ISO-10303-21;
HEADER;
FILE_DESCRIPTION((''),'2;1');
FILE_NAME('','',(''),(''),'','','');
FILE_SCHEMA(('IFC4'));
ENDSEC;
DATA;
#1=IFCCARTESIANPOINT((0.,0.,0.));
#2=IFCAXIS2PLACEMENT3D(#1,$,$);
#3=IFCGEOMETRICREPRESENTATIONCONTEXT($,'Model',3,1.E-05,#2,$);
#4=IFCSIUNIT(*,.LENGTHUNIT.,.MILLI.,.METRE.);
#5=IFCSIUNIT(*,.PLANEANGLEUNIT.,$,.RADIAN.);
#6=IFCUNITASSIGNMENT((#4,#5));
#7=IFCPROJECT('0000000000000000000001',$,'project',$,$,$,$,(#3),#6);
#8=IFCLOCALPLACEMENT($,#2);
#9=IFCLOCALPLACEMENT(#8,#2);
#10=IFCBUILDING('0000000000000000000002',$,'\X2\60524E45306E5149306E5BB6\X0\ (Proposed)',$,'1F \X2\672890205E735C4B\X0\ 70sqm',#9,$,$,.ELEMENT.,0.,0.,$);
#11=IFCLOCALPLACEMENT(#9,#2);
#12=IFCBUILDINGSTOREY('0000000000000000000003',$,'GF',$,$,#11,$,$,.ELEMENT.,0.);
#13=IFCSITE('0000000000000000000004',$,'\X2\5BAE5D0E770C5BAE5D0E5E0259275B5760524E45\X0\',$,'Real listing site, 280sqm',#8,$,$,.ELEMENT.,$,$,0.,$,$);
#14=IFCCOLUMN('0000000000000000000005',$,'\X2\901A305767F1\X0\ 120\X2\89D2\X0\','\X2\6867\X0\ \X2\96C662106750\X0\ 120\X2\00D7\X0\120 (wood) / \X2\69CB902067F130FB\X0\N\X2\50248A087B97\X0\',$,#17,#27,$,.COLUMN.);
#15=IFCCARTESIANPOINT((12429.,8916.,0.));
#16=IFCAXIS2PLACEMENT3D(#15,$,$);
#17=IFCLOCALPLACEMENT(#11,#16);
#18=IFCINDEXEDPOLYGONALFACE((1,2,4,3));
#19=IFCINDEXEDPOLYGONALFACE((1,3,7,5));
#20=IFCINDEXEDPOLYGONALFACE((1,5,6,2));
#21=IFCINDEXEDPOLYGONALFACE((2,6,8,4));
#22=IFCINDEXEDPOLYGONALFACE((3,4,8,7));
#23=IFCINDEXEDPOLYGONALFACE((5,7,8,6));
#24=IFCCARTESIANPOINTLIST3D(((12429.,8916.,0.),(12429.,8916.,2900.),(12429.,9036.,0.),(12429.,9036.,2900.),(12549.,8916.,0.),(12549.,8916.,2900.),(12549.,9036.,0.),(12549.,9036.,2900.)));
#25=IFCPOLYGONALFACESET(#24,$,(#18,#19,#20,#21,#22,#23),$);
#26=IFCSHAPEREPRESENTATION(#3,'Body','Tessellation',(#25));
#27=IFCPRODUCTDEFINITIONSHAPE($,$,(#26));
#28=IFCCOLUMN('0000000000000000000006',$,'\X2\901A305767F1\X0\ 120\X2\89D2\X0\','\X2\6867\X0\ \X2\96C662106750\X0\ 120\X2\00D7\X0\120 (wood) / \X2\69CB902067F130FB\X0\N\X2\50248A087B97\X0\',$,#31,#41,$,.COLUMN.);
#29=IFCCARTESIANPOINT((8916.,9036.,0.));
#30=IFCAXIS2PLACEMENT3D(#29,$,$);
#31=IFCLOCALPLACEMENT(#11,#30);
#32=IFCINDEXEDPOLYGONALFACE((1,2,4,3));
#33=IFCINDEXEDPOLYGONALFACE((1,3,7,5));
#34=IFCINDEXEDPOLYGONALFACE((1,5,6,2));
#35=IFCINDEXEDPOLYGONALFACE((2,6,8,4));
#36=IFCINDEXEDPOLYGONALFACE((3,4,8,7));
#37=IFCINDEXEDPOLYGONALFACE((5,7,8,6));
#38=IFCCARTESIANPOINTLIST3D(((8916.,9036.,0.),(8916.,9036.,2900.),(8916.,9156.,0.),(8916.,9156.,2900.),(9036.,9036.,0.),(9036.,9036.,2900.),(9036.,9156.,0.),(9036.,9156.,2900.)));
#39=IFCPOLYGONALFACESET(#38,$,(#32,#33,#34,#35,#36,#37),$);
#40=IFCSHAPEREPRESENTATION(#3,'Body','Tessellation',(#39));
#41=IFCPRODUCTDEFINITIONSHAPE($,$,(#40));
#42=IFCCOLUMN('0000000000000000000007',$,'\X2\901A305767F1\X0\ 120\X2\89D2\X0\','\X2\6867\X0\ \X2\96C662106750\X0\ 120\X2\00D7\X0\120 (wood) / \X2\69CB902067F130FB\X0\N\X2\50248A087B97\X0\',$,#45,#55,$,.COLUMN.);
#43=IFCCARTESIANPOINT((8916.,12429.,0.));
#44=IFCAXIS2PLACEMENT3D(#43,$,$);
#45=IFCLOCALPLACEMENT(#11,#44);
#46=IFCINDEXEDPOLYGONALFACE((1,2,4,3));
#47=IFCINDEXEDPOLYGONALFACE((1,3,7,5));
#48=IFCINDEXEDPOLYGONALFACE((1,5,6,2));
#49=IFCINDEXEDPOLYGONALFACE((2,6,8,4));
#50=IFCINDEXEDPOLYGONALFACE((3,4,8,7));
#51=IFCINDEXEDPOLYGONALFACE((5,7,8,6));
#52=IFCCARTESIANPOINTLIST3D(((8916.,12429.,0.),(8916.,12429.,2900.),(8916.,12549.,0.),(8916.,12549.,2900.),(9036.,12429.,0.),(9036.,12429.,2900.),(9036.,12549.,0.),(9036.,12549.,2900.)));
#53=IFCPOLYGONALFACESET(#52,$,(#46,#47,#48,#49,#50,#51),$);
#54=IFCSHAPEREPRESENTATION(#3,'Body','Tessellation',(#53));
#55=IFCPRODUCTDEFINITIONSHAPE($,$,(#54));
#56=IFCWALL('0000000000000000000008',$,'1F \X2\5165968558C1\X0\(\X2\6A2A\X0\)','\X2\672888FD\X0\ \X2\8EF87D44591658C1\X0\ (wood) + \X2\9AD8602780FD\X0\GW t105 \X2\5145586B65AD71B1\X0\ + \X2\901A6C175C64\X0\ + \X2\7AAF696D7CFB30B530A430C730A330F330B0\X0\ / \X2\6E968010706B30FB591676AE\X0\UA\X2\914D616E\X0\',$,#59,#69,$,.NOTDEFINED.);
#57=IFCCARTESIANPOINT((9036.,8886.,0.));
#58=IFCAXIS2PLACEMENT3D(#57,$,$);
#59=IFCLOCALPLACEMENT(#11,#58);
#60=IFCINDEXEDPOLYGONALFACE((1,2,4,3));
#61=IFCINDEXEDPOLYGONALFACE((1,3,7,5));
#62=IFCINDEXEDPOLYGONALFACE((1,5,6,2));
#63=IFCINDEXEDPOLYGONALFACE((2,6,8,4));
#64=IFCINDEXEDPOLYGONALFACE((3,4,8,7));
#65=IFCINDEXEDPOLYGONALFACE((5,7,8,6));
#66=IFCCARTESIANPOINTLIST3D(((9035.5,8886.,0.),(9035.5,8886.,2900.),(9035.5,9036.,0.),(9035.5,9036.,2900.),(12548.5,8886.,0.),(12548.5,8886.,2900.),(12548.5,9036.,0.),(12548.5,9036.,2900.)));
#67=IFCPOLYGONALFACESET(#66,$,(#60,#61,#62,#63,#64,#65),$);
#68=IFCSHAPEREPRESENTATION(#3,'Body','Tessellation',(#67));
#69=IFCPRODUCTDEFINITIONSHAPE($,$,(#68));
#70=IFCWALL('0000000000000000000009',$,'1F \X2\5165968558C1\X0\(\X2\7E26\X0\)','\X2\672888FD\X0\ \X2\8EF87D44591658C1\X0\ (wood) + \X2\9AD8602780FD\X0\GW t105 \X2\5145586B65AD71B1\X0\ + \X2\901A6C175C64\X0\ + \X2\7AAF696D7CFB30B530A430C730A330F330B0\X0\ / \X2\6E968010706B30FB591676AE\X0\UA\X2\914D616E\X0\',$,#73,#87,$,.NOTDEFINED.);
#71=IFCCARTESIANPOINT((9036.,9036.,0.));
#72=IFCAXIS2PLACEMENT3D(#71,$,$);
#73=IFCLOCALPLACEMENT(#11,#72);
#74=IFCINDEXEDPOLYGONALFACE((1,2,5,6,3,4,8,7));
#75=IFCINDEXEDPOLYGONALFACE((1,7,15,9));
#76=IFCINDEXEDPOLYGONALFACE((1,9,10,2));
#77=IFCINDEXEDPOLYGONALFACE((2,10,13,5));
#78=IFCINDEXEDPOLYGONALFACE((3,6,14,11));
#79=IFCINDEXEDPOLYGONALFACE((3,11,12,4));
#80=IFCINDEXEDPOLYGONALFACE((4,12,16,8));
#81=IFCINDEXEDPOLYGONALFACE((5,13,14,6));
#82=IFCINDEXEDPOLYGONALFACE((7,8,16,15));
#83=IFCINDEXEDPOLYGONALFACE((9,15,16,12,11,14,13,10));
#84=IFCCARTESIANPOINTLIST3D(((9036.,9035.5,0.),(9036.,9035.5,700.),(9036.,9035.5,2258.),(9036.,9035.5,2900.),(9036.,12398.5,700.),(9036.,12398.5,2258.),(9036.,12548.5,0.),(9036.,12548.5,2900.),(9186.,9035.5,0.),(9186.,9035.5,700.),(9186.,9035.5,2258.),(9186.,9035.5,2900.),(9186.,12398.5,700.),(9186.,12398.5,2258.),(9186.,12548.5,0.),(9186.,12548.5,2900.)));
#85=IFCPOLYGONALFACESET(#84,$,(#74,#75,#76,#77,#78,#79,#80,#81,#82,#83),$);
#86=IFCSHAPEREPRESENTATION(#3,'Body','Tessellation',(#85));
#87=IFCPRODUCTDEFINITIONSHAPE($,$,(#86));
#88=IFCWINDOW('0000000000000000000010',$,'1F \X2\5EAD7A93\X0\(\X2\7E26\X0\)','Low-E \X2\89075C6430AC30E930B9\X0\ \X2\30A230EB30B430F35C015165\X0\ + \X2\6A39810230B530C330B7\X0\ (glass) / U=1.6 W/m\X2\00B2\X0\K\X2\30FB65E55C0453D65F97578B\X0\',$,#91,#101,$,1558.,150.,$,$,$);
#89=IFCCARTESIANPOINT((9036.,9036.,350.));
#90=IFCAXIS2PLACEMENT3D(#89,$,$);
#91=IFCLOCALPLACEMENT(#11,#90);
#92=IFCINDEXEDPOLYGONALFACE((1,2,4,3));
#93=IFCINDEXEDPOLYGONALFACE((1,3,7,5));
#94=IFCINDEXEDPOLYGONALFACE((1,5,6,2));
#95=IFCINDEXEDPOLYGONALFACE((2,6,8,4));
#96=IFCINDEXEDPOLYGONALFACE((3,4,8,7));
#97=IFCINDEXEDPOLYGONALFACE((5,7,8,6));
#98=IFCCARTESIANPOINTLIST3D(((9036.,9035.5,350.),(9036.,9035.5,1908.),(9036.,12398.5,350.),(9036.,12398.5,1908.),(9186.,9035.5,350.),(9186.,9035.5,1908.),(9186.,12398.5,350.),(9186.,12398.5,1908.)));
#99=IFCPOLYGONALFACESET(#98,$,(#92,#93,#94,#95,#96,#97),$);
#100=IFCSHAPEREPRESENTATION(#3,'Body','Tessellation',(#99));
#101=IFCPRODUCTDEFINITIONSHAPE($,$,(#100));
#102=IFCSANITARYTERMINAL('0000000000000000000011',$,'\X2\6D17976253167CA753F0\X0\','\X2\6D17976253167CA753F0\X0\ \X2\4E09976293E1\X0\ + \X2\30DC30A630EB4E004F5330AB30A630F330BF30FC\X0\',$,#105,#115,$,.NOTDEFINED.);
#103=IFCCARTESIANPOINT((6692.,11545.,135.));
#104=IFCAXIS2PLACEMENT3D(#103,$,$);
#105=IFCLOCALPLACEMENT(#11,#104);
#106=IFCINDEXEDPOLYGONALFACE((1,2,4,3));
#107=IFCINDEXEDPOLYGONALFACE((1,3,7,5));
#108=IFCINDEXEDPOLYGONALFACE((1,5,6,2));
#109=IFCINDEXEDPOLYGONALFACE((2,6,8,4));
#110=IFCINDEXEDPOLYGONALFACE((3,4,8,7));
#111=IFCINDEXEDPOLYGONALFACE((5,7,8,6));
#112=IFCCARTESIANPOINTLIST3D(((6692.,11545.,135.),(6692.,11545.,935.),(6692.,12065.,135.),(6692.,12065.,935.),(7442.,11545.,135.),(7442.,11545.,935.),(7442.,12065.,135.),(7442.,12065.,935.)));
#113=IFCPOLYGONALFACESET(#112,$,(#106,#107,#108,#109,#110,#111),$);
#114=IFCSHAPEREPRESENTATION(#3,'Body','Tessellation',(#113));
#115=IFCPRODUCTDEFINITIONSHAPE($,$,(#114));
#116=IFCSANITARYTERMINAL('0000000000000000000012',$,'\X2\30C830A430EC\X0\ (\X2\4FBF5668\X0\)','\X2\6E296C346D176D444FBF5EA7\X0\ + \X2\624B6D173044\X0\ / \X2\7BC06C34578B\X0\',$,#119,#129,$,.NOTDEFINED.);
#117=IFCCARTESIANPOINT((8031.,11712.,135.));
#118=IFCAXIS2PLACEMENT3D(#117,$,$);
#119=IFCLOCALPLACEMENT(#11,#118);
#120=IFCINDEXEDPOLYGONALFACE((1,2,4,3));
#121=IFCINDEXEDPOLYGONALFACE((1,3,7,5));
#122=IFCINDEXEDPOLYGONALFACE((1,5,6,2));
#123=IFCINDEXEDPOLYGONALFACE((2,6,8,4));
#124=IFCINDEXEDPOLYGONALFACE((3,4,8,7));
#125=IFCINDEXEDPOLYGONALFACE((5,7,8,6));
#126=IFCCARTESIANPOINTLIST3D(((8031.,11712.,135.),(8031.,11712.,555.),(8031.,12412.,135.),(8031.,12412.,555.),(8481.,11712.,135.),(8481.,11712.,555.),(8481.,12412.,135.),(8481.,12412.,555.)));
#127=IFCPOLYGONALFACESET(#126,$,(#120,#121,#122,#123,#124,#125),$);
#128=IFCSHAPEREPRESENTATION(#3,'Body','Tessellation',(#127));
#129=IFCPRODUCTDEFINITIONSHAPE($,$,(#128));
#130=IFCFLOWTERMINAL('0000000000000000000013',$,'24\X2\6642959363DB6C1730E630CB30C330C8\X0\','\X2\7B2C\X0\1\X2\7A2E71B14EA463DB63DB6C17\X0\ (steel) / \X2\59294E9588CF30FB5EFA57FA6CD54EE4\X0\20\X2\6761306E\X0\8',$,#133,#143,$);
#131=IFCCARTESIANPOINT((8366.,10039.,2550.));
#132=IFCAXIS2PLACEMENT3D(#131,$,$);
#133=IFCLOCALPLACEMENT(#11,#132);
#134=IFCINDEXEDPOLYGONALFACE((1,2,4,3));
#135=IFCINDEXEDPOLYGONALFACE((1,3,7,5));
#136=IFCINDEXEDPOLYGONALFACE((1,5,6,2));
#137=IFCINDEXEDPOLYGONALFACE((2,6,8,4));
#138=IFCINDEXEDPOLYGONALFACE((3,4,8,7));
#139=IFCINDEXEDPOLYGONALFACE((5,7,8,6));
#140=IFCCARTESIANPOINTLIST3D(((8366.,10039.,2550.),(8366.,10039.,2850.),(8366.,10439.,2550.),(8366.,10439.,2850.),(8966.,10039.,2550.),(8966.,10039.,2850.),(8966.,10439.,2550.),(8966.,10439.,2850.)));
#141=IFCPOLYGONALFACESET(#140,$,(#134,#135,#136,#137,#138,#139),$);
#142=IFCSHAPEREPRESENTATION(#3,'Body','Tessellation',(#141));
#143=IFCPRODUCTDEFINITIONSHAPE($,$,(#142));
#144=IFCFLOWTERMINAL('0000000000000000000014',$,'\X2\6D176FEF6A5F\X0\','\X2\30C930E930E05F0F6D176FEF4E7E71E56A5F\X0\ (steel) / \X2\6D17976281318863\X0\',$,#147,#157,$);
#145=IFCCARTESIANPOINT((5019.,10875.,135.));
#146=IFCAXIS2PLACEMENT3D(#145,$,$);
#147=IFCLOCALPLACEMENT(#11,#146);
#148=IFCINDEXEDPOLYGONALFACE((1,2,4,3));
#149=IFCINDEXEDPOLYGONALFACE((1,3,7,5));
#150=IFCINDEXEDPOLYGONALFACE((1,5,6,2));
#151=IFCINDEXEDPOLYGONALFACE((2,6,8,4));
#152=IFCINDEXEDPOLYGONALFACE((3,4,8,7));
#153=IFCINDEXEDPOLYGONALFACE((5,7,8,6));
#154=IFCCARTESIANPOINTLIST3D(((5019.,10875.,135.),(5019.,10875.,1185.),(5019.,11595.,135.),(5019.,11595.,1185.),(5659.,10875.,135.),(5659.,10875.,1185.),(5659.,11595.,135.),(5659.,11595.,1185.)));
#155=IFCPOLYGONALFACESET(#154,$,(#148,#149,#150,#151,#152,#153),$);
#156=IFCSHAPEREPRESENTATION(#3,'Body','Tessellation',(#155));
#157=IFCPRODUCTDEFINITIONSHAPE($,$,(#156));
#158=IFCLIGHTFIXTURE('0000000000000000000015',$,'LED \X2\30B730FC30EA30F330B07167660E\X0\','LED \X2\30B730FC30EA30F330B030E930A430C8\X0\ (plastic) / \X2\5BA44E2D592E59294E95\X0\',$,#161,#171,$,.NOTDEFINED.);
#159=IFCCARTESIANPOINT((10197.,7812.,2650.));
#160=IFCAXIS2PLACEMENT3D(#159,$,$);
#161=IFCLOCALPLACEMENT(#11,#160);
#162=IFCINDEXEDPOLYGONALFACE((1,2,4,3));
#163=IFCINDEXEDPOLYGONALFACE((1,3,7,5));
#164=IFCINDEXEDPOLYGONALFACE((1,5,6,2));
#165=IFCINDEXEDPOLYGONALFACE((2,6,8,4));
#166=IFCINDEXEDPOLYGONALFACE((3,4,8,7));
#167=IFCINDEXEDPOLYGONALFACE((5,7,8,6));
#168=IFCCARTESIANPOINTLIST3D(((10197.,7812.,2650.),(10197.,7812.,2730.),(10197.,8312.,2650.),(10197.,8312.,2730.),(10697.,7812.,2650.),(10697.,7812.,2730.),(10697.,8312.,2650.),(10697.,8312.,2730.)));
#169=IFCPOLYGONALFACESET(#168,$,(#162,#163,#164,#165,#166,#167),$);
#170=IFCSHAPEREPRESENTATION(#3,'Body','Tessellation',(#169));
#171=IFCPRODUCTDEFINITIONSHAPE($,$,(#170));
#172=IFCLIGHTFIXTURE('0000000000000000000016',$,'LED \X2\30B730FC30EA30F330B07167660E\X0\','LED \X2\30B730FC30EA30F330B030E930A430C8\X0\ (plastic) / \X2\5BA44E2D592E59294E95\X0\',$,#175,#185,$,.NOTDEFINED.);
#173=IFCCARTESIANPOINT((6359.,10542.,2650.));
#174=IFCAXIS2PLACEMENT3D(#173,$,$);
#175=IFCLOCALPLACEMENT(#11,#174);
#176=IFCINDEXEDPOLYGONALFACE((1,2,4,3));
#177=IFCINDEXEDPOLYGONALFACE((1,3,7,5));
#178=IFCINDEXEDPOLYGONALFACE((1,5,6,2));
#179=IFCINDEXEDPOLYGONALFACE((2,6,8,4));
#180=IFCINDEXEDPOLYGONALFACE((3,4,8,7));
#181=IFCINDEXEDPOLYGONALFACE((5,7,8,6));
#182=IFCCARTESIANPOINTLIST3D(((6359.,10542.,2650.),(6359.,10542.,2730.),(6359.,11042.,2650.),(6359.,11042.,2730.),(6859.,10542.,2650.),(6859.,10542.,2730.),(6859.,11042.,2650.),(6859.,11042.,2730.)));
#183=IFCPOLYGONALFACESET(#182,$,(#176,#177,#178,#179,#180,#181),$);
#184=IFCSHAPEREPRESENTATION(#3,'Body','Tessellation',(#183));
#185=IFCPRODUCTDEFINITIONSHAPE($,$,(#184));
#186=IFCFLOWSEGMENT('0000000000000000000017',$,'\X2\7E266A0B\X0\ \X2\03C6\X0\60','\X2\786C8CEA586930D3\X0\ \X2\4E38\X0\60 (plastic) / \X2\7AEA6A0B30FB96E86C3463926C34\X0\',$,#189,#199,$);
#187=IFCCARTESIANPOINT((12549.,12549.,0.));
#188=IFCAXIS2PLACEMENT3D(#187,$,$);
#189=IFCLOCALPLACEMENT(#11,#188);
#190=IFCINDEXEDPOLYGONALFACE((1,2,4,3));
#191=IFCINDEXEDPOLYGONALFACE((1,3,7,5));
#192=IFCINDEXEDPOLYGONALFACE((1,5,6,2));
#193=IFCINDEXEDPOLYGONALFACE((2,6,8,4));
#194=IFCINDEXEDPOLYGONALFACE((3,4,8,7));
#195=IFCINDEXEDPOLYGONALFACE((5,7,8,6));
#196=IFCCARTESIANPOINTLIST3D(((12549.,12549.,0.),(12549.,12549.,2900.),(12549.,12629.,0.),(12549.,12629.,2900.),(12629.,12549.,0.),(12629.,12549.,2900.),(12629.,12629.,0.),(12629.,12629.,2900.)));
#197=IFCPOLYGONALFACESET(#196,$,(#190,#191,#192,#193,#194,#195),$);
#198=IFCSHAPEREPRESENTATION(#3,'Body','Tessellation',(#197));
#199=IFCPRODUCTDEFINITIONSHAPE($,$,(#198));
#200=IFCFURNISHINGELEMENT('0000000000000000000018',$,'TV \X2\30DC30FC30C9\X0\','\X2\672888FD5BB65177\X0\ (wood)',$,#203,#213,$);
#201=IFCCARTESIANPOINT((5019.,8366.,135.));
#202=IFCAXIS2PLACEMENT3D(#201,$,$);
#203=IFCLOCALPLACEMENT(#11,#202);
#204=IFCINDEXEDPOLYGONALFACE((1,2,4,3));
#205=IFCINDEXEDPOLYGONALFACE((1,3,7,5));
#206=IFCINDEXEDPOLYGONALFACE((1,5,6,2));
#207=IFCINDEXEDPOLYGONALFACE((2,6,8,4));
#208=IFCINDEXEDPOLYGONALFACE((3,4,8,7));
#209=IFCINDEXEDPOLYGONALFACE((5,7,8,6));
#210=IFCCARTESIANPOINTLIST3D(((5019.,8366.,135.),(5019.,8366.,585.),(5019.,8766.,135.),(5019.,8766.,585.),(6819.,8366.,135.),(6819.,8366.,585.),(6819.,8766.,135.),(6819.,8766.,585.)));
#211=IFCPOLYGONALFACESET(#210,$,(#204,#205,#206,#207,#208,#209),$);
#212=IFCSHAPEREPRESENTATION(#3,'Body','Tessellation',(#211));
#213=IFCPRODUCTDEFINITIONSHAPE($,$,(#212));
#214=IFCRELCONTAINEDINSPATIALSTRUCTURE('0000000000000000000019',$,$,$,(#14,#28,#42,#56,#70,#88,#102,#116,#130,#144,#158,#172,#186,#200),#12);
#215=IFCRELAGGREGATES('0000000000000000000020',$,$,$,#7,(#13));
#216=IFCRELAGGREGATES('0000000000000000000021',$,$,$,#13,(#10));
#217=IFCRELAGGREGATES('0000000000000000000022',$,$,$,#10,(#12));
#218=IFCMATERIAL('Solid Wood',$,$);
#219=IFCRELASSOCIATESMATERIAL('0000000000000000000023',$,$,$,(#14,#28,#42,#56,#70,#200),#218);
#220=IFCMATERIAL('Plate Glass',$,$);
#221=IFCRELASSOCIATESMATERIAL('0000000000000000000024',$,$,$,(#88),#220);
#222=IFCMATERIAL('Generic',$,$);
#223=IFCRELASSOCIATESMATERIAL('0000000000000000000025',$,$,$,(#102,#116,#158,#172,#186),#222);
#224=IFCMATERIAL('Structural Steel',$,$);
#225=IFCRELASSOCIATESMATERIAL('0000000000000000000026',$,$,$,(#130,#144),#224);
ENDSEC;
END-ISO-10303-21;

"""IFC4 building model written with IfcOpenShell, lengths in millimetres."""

from ifc_helpers import new_model, si_unit, frame, frame_2d, origin, place, context, project, spatial, rectangle, extrude, material, element, fill, save


model = new_model("IFC4")

# Units and contexts
model_context = context("Model", 3, precision=1e-05, world=origin())
ifc_project = project(units=[si_unit("LENGTHUNIT", "METRE", prefix="MILLI"), si_unit("PLANEANGLEUNIT", "RADIAN")], contexts=[model_context])

# Site, building, storey
site_placement = place(None, origin())
site = spatial("IfcSite", under=ifc_project, at=site_placement, Name="宮崎県宮崎市大字恒久", ObjectType="Real listing site, 280sqm", CompositionType="ELEMENT", RefElevation=0.0)
building_placement = place(site_placement, origin())
building = spatial("IfcBuilding", under=site, at=building_placement, Name="恒久の光の家 (Proposed)", ObjectType="1F 木造平屋 70sqm", CompositionType="ELEMENT", ElevationOfRefHeight=0.0, ElevationOfTerrain=0.0)
storey_placement = place(building_placement, origin())
storey = spatial("IfcBuildingStorey", under=building, at=storey_placement, Name="GF", CompositionType="ELEMENT", Elevation=0.0)

# Columns
ifc_material_1 = material(Name="Solid Wood")
column_1_placement = place(storey_placement, frame((12429.0, 8916.0, 0.0)))
element("IfcColumn", 1, at=column_1_placement, inside=storey, material=ifc_material_1, Name="通し柱 120角", Description="桧 集成材 120×120 (wood) / 構造柱・N値計算", PredefinedType="COLUMN", context=model_context, shape_type="SweptSolid", body=[
    extrude(rectangle(XDim=120.0, YDim=120.0, at=frame_2d((60.0, 60.0))), frame((12429.0, 8916.0, 0.0)), (0.0, 0.0, 1.0), 2900.0),
])
column_2_placement = place(storey_placement, frame((8916.0, 9036.0, 0.0)))
element("IfcColumn", 2, at=column_2_placement, inside=storey, material=ifc_material_1, Name="通し柱 120角", Description="桧 集成材 120×120 (wood) / 構造柱・N値計算", PredefinedType="COLUMN", context=model_context, shape_type="SweptSolid", body=[
    extrude(rectangle(XDim=120.0, YDim=120.0, at=frame_2d((60.0, 60.0))), frame((8916.0, 9036.0, 0.0)), (0.0, 0.0, 1.0), 2900.0),
])
column_3_placement = place(storey_placement, frame((8916.0, 12429.0, 0.0)))
element("IfcColumn", 3, at=column_3_placement, inside=storey, material=ifc_material_1, Name="通し柱 120角", Description="桧 集成材 120×120 (wood) / 構造柱・N値計算", PredefinedType="COLUMN", context=model_context, shape_type="SweptSolid", body=[
    extrude(rectangle(XDim=120.0, YDim=120.0, at=frame_2d((60.0, 60.0))), frame((8916.0, 12429.0, 0.0)), (0.0, 0.0, 1.0), 2900.0),
])

# Wall
wall_1_placement = place(storey_placement, frame((9036.0, 8886.0, 0.0)))
element("IfcWall", 4, at=wall_1_placement, inside=storey, material=ifc_material_1, Name="1F 入隅壁(横)", Description="木製 軸組外壁 (wood) + 高性能GW t105 充填断熱 + 通気層 + 窯業系サイディング / 準耐火・外皮UA配慮", PredefinedType="NOTDEFINED", context=model_context, shape_type="SweptSolid", body=[
    extrude(rectangle(XDim=3513.0, YDim=150.0, at=frame_2d((1756.0, 75.0))), frame((9036.0, 8886.0, 0.0)), (0.0, 0.0, 1.0), 2900.0),
])

# Wall, opening, window
wall_2_placement = place(storey_placement, frame((9036.0, 9036.0, 0.0)))
wall_2 = element("IfcWall", 5, at=wall_2_placement, inside=storey, material=ifc_material_1, Name="1F 入隅壁(縦)", Description="木製 軸組外壁 (wood) + 高性能GW t105 充填断熱 + 通気層 + 窯業系サイディング / 準耐火・外皮UA配慮", PredefinedType="NOTDEFINED", context=model_context, shape_type="SweptSolid", body=[
    extrude(rectangle(XDim=150.0, YDim=3513.0, at=frame_2d((75.0, 1756.0))), frame((9036.0, 9036.0, 0.0)), (0.0, 0.0, 1.0), 2900.0),
])
opening_placement = place(storey_placement, frame((9036.0, 9036.0, 350.0)))
opening = element("IfcOpeningElement", 6, at=opening_placement, cuts=wall_2, PredefinedType="NOTDEFINED", context=model_context, shape_type="SweptSolid", body=[
    extrude(rectangle(XDim=150.0, YDim=3363.0, at=frame_2d((75.0, 1681.0))), frame((9036.0, 9036.0, 350.0)), (0.0, 0.0, 1.0), 1558.0),
])
ifc_material_2 = material(Name="Plate Glass")
window_placement = place(storey_placement, frame((9036.0, 9036.0, 350.0)))
window = element("IfcWindow", 7, at=window_placement, inside=storey, material=ifc_material_2, Name="1F 庭窓(縦)", Description="Low-E 複層ガラス アルゴン封入 + 樹脂サッシ (glass) / U=1.6 W/m²K・日射取得型", OverallHeight=1558.0, OverallWidth=150.0, context=model_context, shape_type="SweptSolid", body=[
    extrude(rectangle(XDim=150.0, YDim=3363.0, at=frame_2d((75.0, 1681.0))), frame((9036.0, 9036.0, 350.0)), (0.0, 0.0, 1.0), 1558.0),
])
fill(opening, window)

# Sanitary terminals
ifc_material_3 = material(Name="Generic")
sanitary_terminal_1_placement = place(storey_placement, frame((6692.0, 11545.0, 135.0)))
element("IfcSanitaryTerminal", 8, at=sanitary_terminal_1_placement, inside=storey, material=ifc_material_3, Name="洗面化粧台", Description="洗面化粧台 三面鏡 + ボウル一体カウンター", PredefinedType="NOTDEFINED", context=model_context, shape_type="SweptSolid", body=[
    extrude(rectangle(XDim=750.0, YDim=520.0, at=frame_2d((375.0, 260.0))), frame((6692.0, 11545.0, 135.0)), (0.0, 0.0, 1.0), 800.0),
])
sanitary_terminal_2_placement = place(storey_placement, frame((8031.0, 11712.0, 135.0)))
element("IfcSanitaryTerminal", 9, at=sanitary_terminal_2_placement, inside=storey, material=ifc_material_3, Name="トイレ (便器)", Description="温水洗浄便座 + 手洗い / 節水型", PredefinedType="NOTDEFINED", context=model_context, shape_type="SweptSolid", body=[
    extrude(rectangle(XDim=450.0, YDim=700.0, at=frame_2d((225.0, 350.0))), frame((8031.0, 11712.0, 135.0)), (0.0, 0.0, 1.0), 420.0),
])

# Flow terminals
ifc_material_4 = material(Name="Structural Steel")
flow_terminal_1_placement = place(storey_placement, frame((8366.0, 10039.0, 2550.0)))
element("IfcFlowTerminal", 10, at=flow_terminal_1_placement, inside=storey, material=ifc_material_4, Name="24時間換気ユニット", Description="第1種熱交換換気 (steel) / 天井裏・建基法令20条の8", context=model_context, shape_type="SweptSolid", body=[
    extrude(rectangle(XDim=600.0, YDim=400.0, at=frame_2d((300.0, 200.0))), frame((8366.0, 10039.0, 2550.0)), (0.0, 0.0, 1.0), 300.0),
])
flow_terminal_2_placement = place(storey_placement, frame((5019.0, 10875.0, 135.0)))
element("IfcFlowTerminal", 11, at=flow_terminal_2_placement, inside=storey, material=ifc_material_4, Name="洗濯機", Description="ドラム式洗濯乾燥機 (steel) / 洗面脱衣", context=model_context, shape_type="SweptSolid", body=[
    extrude(rectangle(XDim=640.0, YDim=720.0, at=frame_2d((320.0, 360.0))), frame((5019.0, 10875.0, 135.0)), (0.0, 0.0, 1.0), 1050.0),
])

# Light fixtures
light_fixture_1_placement = place(storey_placement, frame((10197.0, 7812.0, 2650.0)))
element("IfcLightFixture", 12, at=light_fixture_1_placement, inside=storey, material=ifc_material_3, Name="LED シーリング照明", Description="LED シーリングライト (plastic) / 室中央天井", PredefinedType="NOTDEFINED", context=model_context, shape_type="SweptSolid", body=[
    extrude(rectangle(XDim=500.0, YDim=500.0, at=frame_2d((250.0, 250.0))), frame((10197.0, 7812.0, 2650.0)), (0.0, 0.0, 1.0), 80.0),
])
light_fixture_2_placement = place(storey_placement, frame((6359.0, 10542.0, 2650.0)))
element("IfcLightFixture", 13, at=light_fixture_2_placement, inside=storey, material=ifc_material_3, Name="LED シーリング照明", Description="LED シーリングライト (plastic) / 室中央天井", PredefinedType="NOTDEFINED", context=model_context, shape_type="SweptSolid", body=[
    extrude(rectangle(XDim=500.0, YDim=500.0, at=frame_2d((250.0, 250.0))), frame((6359.0, 10542.0, 2650.0)), (0.0, 0.0, 1.0), 80.0),
])

# Flow segment
flow_segment_placement = place(storey_placement, frame((12549.0, 12549.0, 0.0)))
element("IfcFlowSegment", 14, at=flow_segment_placement, inside=storey, material=ifc_material_3, Name="縦樋 φ60", Description="硬質塩ビ 丸60 (plastic) / 竪樋・雨水排水", context=model_context, shape_type="SweptSolid", body=[
    extrude(rectangle(XDim=80.0, YDim=80.0, at=frame_2d((40.0, 40.0))), frame((12549.0, 12549.0, 0.0)), (0.0, 0.0, 1.0), 2900.0),
])

# Furnishing element
furnishing_placement = place(storey_placement, frame((5019.0, 8366.0, 135.0)))
element("IfcFurnishingElement", 15, at=furnishing_placement, inside=storey, material=ifc_material_1, Name="TV ボード", Description="木製家具 (wood)", context=model_context, shape_type="SweptSolid", body=[
    extrude(rectangle(XDim=1800.0, YDim=400.0, at=frame_2d((900.0, 200.0))), frame((5019.0, 8366.0, 135.0)), (0.0, 0.0, 1.0), 450.0),
])

save(model, "model.ifc")
